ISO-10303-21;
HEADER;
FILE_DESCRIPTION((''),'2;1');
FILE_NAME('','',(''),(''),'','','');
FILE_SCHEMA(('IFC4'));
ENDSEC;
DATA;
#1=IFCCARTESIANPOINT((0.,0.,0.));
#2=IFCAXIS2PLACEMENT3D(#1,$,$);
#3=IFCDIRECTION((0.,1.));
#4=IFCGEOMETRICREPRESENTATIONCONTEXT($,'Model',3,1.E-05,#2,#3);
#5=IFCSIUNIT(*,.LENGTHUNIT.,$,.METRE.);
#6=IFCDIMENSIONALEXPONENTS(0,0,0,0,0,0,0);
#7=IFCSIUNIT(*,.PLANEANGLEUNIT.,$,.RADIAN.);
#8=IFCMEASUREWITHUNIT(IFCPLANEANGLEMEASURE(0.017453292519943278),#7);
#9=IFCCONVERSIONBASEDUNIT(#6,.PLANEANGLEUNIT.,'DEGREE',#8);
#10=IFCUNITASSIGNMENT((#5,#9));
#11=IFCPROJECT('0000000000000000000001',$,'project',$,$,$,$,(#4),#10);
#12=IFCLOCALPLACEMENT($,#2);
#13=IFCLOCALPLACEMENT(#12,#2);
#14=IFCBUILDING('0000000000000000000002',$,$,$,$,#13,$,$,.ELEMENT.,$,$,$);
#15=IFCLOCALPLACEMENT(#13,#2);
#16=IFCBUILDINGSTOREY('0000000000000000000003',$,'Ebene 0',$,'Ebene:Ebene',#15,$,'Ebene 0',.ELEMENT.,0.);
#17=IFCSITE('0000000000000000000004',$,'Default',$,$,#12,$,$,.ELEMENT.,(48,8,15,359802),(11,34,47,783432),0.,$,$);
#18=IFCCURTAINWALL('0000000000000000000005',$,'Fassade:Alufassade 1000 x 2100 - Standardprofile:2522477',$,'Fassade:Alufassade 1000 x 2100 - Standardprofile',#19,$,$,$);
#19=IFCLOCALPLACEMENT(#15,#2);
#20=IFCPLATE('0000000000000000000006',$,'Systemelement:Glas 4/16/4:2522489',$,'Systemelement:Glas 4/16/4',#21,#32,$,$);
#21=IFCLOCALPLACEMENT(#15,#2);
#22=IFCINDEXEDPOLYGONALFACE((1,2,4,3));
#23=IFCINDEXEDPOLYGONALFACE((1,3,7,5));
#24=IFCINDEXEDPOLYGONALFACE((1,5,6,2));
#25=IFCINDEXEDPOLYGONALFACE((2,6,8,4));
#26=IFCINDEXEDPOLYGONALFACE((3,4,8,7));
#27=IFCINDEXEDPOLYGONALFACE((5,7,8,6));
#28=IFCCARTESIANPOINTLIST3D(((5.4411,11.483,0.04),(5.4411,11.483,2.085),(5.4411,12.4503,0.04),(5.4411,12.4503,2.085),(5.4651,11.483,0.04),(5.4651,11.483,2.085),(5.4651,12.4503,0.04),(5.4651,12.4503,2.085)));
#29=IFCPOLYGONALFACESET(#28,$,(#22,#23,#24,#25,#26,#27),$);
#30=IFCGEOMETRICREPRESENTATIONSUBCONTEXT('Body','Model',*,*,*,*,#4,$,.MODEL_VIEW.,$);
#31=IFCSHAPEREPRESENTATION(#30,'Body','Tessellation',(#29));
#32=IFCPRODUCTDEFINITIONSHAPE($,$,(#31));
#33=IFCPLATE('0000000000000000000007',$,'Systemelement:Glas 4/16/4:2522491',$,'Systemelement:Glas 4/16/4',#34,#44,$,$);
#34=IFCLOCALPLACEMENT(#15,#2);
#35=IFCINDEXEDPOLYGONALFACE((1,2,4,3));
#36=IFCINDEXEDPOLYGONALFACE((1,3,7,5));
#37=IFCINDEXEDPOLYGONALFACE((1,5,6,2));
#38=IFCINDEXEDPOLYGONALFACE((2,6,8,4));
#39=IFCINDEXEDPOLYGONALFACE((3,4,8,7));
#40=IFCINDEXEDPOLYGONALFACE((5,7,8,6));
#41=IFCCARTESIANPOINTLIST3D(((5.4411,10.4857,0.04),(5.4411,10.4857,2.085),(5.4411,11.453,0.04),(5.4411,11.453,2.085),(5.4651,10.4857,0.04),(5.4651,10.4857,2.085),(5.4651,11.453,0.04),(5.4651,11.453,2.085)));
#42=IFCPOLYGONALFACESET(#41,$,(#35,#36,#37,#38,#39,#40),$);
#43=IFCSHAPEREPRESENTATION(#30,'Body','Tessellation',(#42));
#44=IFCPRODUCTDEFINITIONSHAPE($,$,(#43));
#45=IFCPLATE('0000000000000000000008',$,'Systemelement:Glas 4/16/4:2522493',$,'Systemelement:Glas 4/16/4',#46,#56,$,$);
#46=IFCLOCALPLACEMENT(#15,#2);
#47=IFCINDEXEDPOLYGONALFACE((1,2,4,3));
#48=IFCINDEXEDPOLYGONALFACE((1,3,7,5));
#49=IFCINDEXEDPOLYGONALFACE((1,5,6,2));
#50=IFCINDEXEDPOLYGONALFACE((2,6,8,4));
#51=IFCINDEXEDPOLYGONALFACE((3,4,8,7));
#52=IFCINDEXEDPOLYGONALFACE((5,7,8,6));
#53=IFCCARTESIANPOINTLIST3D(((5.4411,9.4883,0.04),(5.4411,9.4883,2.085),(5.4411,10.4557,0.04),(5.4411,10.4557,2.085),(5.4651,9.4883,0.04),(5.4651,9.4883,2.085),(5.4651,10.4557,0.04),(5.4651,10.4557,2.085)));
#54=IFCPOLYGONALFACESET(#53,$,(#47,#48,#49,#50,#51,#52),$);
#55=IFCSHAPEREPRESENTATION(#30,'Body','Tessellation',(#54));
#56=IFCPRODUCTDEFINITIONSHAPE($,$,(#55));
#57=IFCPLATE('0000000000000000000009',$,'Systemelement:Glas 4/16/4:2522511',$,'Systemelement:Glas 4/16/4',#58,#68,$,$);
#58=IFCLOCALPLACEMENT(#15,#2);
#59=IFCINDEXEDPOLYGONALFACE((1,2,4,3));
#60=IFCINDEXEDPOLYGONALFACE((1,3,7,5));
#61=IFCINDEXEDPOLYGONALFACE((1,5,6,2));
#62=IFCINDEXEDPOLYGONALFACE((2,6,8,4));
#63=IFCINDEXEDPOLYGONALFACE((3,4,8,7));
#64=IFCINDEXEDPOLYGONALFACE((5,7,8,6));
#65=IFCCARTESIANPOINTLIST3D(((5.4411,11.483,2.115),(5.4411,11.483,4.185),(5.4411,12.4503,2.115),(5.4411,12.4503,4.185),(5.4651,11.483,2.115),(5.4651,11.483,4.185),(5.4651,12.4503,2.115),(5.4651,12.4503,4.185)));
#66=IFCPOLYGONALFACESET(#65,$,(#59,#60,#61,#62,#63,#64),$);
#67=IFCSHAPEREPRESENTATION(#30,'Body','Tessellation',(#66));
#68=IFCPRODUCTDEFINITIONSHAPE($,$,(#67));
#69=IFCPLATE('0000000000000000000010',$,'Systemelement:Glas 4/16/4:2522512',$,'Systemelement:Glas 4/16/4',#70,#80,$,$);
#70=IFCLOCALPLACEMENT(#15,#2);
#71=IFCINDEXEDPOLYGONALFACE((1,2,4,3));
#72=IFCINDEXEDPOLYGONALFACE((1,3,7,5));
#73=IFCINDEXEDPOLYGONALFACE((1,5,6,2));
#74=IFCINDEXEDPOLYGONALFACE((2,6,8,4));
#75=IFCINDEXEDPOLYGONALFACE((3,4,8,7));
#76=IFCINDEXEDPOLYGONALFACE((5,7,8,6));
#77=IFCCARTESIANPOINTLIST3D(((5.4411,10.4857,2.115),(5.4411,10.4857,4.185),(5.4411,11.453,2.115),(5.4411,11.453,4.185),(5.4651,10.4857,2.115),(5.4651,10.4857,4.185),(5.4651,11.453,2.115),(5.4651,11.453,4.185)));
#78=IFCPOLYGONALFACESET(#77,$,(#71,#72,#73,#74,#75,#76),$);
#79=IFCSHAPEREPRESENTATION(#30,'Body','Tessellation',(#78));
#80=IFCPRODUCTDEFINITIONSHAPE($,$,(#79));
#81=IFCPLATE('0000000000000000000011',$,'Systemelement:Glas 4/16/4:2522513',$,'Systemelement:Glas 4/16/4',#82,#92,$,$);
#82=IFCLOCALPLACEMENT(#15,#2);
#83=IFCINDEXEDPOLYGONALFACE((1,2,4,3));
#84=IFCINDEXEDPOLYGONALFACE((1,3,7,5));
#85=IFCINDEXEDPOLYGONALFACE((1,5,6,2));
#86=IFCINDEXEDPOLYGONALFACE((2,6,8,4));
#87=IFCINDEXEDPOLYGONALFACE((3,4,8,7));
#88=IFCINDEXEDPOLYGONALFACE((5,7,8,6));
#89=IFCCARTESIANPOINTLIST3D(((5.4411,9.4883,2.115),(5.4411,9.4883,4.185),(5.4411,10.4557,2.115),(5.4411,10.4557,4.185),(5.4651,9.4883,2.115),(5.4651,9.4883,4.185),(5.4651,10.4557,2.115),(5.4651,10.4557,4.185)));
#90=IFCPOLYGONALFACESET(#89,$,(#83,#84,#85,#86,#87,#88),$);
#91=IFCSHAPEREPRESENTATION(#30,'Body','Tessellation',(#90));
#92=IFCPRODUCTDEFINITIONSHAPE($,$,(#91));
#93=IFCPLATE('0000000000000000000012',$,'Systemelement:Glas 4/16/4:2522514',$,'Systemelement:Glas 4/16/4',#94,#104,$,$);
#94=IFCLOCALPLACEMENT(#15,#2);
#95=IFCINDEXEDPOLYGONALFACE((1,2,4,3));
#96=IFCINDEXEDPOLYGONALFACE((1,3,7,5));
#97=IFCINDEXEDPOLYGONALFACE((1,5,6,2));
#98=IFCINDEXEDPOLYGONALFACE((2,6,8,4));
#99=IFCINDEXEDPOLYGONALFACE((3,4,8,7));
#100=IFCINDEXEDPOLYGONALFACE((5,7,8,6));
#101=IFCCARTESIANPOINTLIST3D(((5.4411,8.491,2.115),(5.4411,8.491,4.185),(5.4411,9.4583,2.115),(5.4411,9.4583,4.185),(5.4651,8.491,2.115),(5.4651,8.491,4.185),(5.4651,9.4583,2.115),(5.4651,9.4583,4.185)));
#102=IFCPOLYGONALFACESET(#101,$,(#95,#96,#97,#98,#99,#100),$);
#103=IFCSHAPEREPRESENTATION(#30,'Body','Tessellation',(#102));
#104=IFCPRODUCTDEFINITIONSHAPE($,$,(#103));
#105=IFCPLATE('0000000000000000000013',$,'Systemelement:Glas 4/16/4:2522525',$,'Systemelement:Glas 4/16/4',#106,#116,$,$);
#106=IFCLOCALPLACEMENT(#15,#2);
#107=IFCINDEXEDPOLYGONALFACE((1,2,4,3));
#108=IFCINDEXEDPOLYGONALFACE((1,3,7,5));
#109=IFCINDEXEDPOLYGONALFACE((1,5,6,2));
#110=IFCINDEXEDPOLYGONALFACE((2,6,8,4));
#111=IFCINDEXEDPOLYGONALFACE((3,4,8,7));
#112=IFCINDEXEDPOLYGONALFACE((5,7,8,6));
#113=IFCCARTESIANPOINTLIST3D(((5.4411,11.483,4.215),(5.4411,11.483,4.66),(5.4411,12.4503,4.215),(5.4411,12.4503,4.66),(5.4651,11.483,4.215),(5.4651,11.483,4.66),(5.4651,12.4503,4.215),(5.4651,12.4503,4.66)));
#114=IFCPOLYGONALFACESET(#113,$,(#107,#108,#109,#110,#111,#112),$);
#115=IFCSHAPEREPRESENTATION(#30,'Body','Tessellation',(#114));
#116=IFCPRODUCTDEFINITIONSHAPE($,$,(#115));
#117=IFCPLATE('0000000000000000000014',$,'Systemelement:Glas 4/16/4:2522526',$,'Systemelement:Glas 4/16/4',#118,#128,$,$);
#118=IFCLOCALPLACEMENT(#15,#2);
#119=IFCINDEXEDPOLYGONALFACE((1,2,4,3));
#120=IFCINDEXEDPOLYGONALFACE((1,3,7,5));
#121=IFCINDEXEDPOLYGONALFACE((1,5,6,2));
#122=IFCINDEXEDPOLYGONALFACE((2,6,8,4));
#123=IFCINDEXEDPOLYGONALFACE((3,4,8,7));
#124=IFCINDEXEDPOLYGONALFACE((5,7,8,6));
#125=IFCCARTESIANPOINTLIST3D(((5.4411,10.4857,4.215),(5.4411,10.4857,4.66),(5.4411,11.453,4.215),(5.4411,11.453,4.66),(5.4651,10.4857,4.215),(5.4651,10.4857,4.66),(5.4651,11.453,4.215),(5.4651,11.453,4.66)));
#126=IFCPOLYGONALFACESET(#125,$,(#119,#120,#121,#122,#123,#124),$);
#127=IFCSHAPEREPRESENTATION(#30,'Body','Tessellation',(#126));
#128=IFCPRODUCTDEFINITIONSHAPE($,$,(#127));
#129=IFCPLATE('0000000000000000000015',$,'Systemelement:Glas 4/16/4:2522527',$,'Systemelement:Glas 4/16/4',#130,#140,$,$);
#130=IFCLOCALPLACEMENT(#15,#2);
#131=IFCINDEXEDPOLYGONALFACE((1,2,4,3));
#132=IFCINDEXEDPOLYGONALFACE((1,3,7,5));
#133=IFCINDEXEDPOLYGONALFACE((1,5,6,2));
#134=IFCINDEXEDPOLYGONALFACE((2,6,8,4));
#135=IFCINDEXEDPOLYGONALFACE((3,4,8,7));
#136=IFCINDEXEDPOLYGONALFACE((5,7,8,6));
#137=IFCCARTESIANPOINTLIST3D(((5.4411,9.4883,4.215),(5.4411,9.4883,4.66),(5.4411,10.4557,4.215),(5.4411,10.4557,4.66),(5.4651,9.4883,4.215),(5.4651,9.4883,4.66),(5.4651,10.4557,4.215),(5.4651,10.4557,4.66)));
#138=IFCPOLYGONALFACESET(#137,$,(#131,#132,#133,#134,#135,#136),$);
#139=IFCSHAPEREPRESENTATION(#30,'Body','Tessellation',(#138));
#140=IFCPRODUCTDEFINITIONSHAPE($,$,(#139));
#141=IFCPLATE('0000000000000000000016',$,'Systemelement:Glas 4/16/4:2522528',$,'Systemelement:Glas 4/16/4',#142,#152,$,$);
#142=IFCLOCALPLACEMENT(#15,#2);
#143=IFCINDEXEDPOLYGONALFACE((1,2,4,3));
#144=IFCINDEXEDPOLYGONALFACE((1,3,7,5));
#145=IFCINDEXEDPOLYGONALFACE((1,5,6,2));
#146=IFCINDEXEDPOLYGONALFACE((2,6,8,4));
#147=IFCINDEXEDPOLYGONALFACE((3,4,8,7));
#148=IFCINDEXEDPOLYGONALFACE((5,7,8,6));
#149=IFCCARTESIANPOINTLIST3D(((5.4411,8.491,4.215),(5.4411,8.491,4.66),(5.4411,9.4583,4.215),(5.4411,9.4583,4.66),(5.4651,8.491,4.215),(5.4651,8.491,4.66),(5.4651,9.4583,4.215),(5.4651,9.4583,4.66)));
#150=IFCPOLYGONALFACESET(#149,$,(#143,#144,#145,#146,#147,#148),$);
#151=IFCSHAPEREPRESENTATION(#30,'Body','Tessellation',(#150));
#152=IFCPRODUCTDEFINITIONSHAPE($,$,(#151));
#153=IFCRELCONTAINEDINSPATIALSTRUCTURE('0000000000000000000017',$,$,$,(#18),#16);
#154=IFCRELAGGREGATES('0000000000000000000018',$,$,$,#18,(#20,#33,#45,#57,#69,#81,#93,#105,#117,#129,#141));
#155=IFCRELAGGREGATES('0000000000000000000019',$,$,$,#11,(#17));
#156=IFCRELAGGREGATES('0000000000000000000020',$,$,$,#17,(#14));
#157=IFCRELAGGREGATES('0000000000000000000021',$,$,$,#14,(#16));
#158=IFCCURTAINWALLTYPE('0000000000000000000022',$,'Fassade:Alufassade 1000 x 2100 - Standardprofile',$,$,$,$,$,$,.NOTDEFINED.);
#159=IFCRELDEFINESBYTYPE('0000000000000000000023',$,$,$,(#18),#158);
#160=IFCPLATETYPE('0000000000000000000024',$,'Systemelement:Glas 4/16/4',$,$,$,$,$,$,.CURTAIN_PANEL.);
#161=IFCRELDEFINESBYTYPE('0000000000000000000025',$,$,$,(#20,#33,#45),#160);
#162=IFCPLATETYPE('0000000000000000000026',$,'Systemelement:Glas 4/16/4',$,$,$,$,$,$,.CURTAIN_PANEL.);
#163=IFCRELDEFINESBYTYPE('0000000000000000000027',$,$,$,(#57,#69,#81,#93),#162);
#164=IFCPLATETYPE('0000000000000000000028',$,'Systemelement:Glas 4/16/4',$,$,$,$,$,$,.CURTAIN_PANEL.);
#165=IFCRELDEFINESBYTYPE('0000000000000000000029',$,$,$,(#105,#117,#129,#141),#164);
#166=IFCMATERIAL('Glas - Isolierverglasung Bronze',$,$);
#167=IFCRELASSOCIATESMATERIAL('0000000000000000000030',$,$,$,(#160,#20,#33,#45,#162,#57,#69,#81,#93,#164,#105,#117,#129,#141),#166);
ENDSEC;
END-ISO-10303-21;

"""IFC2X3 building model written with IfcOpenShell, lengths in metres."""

from ifc_helpers import new_model, entity, si_unit, converted_unit, direction, frame, origin, origin_2d_with_axis, place, context, subcontext, project, spatial, rectangle, extrude, source, transform, mapped, material, type_object, type_shapes, element, aggregate, save


model = new_model("IFC2X3")

# Units and contexts
model_context = context("Model", 3, precision=1e-05, world=origin(), true_north=direction((0.0, 1.0)))
body_context = subcontext(model_context, "Body", "Model", "MODEL_VIEW")
ifc_project = project(units=[si_unit("LENGTHUNIT", "METRE"), converted_unit("PLANEANGLEUNIT", "DEGREE", entity("IfcPlaneAngleMeasure", 0.017453292519943278), si_unit("PLANEANGLEUNIT", "RADIAN"), dimensions=[0, 0, 0, 0, 0, 0, 0])], contexts=[model_context])

# Site, building, storey
site_placement = place(None, origin())
site = spatial("IfcSite", under=ifc_project, at=site_placement, Name="Default", CompositionType="ELEMENT", RefLatitude=(48, 8, 15, 359802), RefLongitude=(11, 34, 47, 783432), RefElevation=0.0)
building_placement = place(site_placement, origin())
building = spatial("IfcBuilding", under=site, at=building_placement, CompositionType="ELEMENT")
storey_placement = place(building_placement, origin())
storey = spatial("IfcBuildingStorey", under=building, at=storey_placement, Name="Ebene 0", ObjectType="Ebene:Ebene", LongName="Ebene 0", CompositionType="ELEMENT", Elevation=0.0)

# Curtain wall, plates
curtain_wall_type = type_object("IfcCurtainWallType", Name="Fassade:Alufassade 1000 x 2100 - Standardprofile", PredefinedType="NOTDEFINED")
curtain_wall_placement = place(storey_placement, origin())
curtain_wall = element("IfcCurtainWall", 1, at=curtain_wall_placement, inside=storey, type_object=curtain_wall_type, Name="Fassade:Alufassade 1000 x 2100 - Standardprofile:2522477", ObjectType="Fassade:Alufassade 1000 x 2100 - Standardprofile")
ifc_material_1 = material(Name="Glas - Isolierverglasung Bronze")
plate_type_1 = type_object("IfcPlateType", Name="Systemelement:Glas 4/16/4", PredefinedType="CURTAIN_PANEL", material=ifc_material_1)
shared_shape_1 = source(origin(), body_context, "Body", "SweptSolid", [
    extrude(rectangle(XDim=0.024, YDim=0.9673, at=origin_2d_with_axis()), frame((0.0, 0.0, 0.0), z_axis=(0.0, 0.0, 1.0), x_axis=(0.0, 1.0, 0.0)), (0.0, 0.0, 1.0), 2.045),
])
type_shapes(plate_type_1, [shared_shape_1])
plate_1_placement = place(curtain_wall_placement, frame((5.4531, 11.9666, 0.04), z_axis=(0.0, 0.0, 1.0), x_axis=(0.0, -1.0, 0.0)))
plate_1 = element("IfcPlate", 2, at=plate_1_placement, type_object=plate_type_1, material=ifc_material_1, Name="Systemelement:Glas 4/16/4:2522489", ObjectType="Systemelement:Glas 4/16/4", context=body_context, shape_type="MappedRepresentation", body=[
    mapped(shared_shape_1, transform((0.0, 0.0, 0.0), scale=1.0)),
])
plate_2_placement = place(curtain_wall_placement, frame((5.4531, 10.9693, 0.04), z_axis=(0.0, 0.0, 1.0), x_axis=(0.0, -1.0, 0.0)))
plate_2 = element("IfcPlate", 3, at=plate_2_placement, type_object=plate_type_1, material=ifc_material_1, Name="Systemelement:Glas 4/16/4:2522491", ObjectType="Systemelement:Glas 4/16/4", context=body_context, shape_type="MappedRepresentation", body=[
    mapped(shared_shape_1, transform((0.0, 0.0, 0.0), scale=1.0)),
])
plate_3_placement = place(curtain_wall_placement, frame((5.4531, 9.972, 0.04), z_axis=(0.0, 0.0, 1.0), x_axis=(0.0, -1.0, 0.0)))
plate_3 = element("IfcPlate", 4, at=plate_3_placement, type_object=plate_type_1, material=ifc_material_1, Name="Systemelement:Glas 4/16/4:2522493", ObjectType="Systemelement:Glas 4/16/4", context=body_context, shape_type="MappedRepresentation", body=[
    mapped(shared_shape_1, transform((0.0, 0.0, 0.0), scale=1.0)),
])
plate_type_2 = type_object("IfcPlateType", Name="Systemelement:Glas 4/16/4", PredefinedType="CURTAIN_PANEL", material=ifc_material_1)
shared_shape_2 = source(origin(), body_context, "Body", "SweptSolid", [
    extrude(rectangle(XDim=0.024, YDim=0.9673, at=origin_2d_with_axis()), frame((0.0, 0.0, 0.0), z_axis=(0.0, 0.0, 1.0), x_axis=(0.0, 1.0, 0.0)), (0.0, 0.0, 1.0), 2.07),
])
type_shapes(plate_type_2, [shared_shape_2])
plate_4_placement = place(curtain_wall_placement, frame((5.4531, 11.9666, 2.115), z_axis=(0.0, 0.0, 1.0), x_axis=(0.0, -1.0, 0.0)))
plate_4 = element("IfcPlate", 5, at=plate_4_placement, type_object=plate_type_2, material=ifc_material_1, Name="Systemelement:Glas 4/16/4:2522511", ObjectType="Systemelement:Glas 4/16/4", context=body_context, shape_type="MappedRepresentation", body=[
    mapped(shared_shape_2, transform((0.0, 0.0, 0.0), scale=1.0)),
])
plate_5_placement = place(curtain_wall_placement, frame((5.4531, 10.9693, 2.115), z_axis=(0.0, 0.0, 1.0), x_axis=(0.0, -1.0, 0.0)))
plate_5 = element("IfcPlate", 6, at=plate_5_placement, type_object=plate_type_2, material=ifc_material_1, Name="Systemelement:Glas 4/16/4:2522512", ObjectType="Systemelement:Glas 4/16/4", context=body_context, shape_type="MappedRepresentation", body=[
    mapped(shared_shape_2, transform((0.0, 0.0, 0.0), scale=1.0)),
])
plate_6_placement = place(curtain_wall_placement, frame((5.4531, 9.972, 2.115), z_axis=(0.0, 0.0, 1.0), x_axis=(0.0, -1.0, 0.0)))
plate_6 = element("IfcPlate", 7, at=plate_6_placement, type_object=plate_type_2, material=ifc_material_1, Name="Systemelement:Glas 4/16/4:2522513", ObjectType="Systemelement:Glas 4/16/4", context=body_context, shape_type="MappedRepresentation", body=[
    mapped(shared_shape_2, transform((0.0, 0.0, 0.0), scale=1.0)),
])
plate_7_placement = place(curtain_wall_placement, frame((5.4531, 8.9747, 2.115), z_axis=(0.0, 0.0, 1.0), x_axis=(0.0, -1.0, 0.0)))
plate_7 = element("IfcPlate", 8, at=plate_7_placement, type_object=plate_type_2, material=ifc_material_1, Name="Systemelement:Glas 4/16/4:2522514", ObjectType="Systemelement:Glas 4/16/4", context=body_context, shape_type="MappedRepresentation", body=[
    mapped(shared_shape_2, transform((0.0, 0.0, 0.0), scale=1.0)),
])
plate_type_3 = type_object("IfcPlateType", Name="Systemelement:Glas 4/16/4", PredefinedType="CURTAIN_PANEL", material=ifc_material_1)
shared_shape_3 = source(origin(), body_context, "Body", "SweptSolid", [
    extrude(rectangle(XDim=0.024, YDim=0.9673, at=origin_2d_with_axis()), frame((0.0, 0.0, 0.0), z_axis=(0.0, 0.0, 1.0), x_axis=(0.0, 1.0, 0.0)), (0.0, 0.0, 1.0), 0.445),
])
type_shapes(plate_type_3, [shared_shape_3])
plate_8_placement = place(curtain_wall_placement, frame((5.4531, 11.9666, 4.215), z_axis=(0.0, 0.0, 1.0), x_axis=(0.0, -1.0, 0.0)))
plate_8 = element("IfcPlate", 9, at=plate_8_placement, type_object=plate_type_3, material=ifc_material_1, Name="Systemelement:Glas 4/16/4:2522525", ObjectType="Systemelement:Glas 4/16/4", context=body_context, shape_type="MappedRepresentation", body=[
    mapped(shared_shape_3, transform((0.0, 0.0, 0.0), scale=1.0)),
])
plate_9_placement = place(curtain_wall_placement, frame((5.4531, 10.9693, 4.215), z_axis=(0.0, 0.0, 1.0), x_axis=(0.0, -1.0, 0.0)))
plate_9 = element("IfcPlate", 10, at=plate_9_placement, type_object=plate_type_3, material=ifc_material_1, Name="Systemelement:Glas 4/16/4:2522526", ObjectType="Systemelement:Glas 4/16/4", context=body_context, shape_type="MappedRepresentation", body=[
    mapped(shared_shape_3, transform((0.0, 0.0, 0.0), scale=1.0)),
])
plate_10_placement = place(curtain_wall_placement, frame((5.4531, 9.972, 4.215), z_axis=(0.0, 0.0, 1.0), x_axis=(0.0, -1.0, 0.0)))
plate_10 = element("IfcPlate", 11, at=plate_10_placement, type_object=plate_type_3, material=ifc_material_1, Name="Systemelement:Glas 4/16/4:2522527", ObjectType="Systemelement:Glas 4/16/4", context=body_context, shape_type="MappedRepresentation", body=[
    mapped(shared_shape_3, transform((0.0, 0.0, 0.0), scale=1.0)),
])
plate_11_placement = place(curtain_wall_placement, frame((5.4531, 8.9747, 4.215), z_axis=(0.0, 0.0, 1.0), x_axis=(0.0, -1.0, 0.0)))
plate_11 = element("IfcPlate", 12, at=plate_11_placement, type_object=plate_type_3, material=ifc_material_1, Name="Systemelement:Glas 4/16/4:2522528", ObjectType="Systemelement:Glas 4/16/4", context=body_context, shape_type="MappedRepresentation", body=[
    mapped(shared_shape_3, transform((0.0, 0.0, 0.0), scale=1.0)),
])
aggregate(curtain_wall, [plate_1, plate_2, plate_3, plate_4, plate_5, plate_6, plate_7, plate_8, plate_9, plate_10, plate_11])

save(model, "model.ifc")
